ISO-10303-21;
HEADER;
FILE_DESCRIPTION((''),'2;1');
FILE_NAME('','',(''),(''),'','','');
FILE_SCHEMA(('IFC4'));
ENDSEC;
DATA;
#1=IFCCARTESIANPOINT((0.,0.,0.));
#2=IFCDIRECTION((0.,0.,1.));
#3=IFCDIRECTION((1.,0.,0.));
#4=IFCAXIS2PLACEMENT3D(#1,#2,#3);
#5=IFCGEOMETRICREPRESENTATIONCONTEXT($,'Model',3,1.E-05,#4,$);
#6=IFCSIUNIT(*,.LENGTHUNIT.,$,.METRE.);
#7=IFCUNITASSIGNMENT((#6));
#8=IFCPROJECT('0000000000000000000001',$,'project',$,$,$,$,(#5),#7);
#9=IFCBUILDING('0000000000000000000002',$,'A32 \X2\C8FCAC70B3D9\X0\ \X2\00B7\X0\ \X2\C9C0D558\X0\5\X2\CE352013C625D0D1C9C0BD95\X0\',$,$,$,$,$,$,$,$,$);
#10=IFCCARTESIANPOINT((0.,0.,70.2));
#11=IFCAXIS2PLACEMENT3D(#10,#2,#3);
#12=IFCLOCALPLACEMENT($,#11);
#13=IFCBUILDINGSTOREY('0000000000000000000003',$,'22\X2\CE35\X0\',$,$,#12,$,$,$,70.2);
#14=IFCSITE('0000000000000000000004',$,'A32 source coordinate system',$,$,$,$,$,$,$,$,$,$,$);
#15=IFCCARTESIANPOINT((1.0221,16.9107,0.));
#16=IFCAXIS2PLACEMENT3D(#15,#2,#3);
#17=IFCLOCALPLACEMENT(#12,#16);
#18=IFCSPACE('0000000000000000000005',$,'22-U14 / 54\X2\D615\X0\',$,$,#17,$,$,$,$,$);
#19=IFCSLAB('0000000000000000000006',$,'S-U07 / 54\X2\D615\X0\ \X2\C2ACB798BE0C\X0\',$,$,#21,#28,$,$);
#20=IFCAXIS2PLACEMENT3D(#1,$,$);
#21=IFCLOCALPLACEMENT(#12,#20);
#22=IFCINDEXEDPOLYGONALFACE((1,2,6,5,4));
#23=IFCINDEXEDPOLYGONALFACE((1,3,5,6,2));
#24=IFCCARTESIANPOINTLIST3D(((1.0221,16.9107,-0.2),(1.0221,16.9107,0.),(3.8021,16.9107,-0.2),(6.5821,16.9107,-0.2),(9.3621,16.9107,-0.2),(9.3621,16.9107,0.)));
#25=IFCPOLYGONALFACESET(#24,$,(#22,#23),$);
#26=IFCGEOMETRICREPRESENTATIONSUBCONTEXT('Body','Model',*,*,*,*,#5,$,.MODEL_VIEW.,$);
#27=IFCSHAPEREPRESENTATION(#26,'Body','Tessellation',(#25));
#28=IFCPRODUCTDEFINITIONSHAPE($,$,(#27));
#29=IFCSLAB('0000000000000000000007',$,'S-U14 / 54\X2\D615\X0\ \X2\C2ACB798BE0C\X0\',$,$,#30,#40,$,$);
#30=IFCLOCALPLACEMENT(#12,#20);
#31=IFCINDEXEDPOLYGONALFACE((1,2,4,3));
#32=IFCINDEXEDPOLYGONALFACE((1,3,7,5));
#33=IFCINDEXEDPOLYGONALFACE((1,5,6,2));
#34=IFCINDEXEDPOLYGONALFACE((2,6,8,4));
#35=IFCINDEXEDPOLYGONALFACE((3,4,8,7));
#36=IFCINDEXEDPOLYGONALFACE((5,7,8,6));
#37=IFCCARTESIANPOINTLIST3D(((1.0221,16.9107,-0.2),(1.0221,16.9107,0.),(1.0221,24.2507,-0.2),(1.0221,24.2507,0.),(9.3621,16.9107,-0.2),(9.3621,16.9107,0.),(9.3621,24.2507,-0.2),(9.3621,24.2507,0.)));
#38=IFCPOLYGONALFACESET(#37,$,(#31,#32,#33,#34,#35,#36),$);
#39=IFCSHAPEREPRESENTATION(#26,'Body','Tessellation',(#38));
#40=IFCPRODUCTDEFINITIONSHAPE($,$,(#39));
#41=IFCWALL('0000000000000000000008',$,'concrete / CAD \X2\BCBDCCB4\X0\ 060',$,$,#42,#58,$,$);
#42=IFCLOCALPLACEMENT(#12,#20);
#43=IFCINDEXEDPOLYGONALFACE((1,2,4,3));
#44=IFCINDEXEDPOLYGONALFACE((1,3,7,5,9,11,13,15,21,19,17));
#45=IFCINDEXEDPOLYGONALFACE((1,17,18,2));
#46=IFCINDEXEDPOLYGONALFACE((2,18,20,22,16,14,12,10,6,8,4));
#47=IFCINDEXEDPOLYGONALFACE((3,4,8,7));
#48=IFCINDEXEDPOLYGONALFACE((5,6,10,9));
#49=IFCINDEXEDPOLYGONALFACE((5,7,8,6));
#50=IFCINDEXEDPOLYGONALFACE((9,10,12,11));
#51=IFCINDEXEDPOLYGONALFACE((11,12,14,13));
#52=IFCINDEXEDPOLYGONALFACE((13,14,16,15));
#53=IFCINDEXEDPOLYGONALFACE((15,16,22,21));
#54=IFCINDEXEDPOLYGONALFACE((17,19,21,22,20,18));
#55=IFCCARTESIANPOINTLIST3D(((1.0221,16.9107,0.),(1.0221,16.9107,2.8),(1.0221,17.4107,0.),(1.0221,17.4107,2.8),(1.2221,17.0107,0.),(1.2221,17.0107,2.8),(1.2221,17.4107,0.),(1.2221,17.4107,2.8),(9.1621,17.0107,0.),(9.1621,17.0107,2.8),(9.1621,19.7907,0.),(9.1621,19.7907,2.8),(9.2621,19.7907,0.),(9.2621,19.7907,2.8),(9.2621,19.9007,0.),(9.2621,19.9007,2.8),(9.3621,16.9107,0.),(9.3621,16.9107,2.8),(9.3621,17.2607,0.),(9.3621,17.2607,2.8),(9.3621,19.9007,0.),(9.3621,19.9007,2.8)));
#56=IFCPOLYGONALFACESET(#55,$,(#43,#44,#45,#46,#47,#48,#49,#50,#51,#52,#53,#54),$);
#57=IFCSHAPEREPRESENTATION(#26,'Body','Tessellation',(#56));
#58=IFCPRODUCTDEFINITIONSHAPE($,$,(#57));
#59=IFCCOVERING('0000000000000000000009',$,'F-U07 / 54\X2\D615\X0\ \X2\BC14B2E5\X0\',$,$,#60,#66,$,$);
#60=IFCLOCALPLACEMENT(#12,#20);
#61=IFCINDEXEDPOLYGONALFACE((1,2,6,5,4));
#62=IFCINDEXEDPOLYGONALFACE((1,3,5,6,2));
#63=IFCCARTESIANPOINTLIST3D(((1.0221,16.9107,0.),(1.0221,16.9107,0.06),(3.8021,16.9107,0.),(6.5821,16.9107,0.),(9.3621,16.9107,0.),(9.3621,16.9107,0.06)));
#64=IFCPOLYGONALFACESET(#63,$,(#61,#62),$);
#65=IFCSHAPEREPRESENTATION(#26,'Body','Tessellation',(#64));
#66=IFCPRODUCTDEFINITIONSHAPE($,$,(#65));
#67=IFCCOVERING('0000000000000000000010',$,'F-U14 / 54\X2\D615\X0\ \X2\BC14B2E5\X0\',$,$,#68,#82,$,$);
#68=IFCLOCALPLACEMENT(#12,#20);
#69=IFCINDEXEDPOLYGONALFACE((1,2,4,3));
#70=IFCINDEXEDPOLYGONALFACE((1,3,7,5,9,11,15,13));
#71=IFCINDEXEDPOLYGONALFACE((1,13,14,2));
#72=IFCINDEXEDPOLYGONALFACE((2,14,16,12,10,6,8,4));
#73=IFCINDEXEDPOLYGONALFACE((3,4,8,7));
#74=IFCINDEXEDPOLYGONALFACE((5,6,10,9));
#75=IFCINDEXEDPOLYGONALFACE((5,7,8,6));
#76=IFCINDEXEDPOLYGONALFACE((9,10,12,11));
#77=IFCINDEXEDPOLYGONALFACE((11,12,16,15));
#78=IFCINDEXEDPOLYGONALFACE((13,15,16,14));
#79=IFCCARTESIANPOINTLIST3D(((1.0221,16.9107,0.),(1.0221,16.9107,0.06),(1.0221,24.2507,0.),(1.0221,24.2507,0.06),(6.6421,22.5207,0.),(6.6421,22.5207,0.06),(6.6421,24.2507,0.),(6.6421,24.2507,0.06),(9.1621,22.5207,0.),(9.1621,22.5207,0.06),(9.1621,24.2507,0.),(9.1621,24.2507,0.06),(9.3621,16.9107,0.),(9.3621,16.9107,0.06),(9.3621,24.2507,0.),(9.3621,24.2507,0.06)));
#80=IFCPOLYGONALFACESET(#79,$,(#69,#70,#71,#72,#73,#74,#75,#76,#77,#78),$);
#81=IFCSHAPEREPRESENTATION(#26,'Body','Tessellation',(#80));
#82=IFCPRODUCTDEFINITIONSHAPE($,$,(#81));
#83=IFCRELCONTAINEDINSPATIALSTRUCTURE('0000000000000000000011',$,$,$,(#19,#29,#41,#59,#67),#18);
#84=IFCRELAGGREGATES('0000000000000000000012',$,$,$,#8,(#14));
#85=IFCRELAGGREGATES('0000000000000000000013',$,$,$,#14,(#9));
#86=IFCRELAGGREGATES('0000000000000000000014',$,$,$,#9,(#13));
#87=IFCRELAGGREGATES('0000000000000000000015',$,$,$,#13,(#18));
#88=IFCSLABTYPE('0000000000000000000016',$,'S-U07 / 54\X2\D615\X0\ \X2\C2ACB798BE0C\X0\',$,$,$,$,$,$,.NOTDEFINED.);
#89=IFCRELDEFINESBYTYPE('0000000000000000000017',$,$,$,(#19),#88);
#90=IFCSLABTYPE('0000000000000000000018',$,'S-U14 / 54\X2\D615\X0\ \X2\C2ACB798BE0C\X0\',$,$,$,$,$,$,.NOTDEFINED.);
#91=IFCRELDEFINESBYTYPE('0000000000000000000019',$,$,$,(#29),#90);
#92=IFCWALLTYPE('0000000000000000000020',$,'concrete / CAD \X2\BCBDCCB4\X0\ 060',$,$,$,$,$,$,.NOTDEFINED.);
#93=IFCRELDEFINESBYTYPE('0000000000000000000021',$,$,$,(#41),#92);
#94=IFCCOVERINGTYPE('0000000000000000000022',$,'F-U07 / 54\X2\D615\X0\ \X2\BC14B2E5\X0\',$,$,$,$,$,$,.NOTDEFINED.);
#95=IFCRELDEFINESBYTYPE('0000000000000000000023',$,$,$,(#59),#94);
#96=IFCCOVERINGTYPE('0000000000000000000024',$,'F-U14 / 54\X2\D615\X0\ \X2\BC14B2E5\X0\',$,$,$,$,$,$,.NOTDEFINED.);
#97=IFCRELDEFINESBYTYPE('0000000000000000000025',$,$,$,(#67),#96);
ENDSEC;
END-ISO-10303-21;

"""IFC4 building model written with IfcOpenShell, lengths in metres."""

from ifc_helpers import new_model, si_unit, frame, origin, origin_with_axes, place, context, subcontext, project, spatial, polyline, outline, extrude, source, transform, mapped, type_object, type_shapes, element, save


model = new_model("IFC4")

# Units and contexts
model_context = context("Model", 3, precision=1e-05, world=origin_with_axes())
body_context = subcontext(model_context, "Body", "Model", "MODEL_VIEW")
ifc_project = project(units=[si_unit("LENGTHUNIT", "METRE")], contexts=[model_context])

# Site, building, storey, space
storey_placement = place(None, frame((0.0, 0.0, 70.2), z_axis=(0.0, 0.0, 1.0), x_axis=(1.0, 0.0, 0.0)))
space_1_placement = place(storey_placement, frame((1.0221, 16.9107, 0.0), z_axis=(0.0, 0.0, 1.0), x_axis=(1.0, 0.0, 0.0)))
site = spatial("IfcSite", under=ifc_project, Name="A32 source coordinate system")
building = spatial("IfcBuilding", under=site, Name="A32 주거동 · 지하5층–옥탑지붕")
storey = spatial("IfcBuildingStorey", under=building, at=storey_placement, Name="22층", Elevation=70.2)
space_1 = spatial("IfcSpace", under=storey, at=space_1_placement, Name="22-U14 / 54형")

# Slabs
slab_type_1 = type_object("IfcSlabType", Name="S-U07 / 54형 슬래브", PredefinedType="NOTDEFINED")
shared_shape_1 = source(origin(), body_context, "Body", "SweptSolid", [
    extrude(outline(polyline([(0.0, 0.0), (0.0, 0.0), (8.34, 0.0), (8.34, 0.0), (0.0, 0.0)])), frame((0.0, 0.0, -0.2)), (0.0, 0.0, 1.0), 0.2),
])
type_shapes(slab_type_1, [shared_shape_1])
slab_1_placement = place(space_1_placement, origin_with_axes())
element("IfcSlab", 1, at=slab_1_placement, inside=space_1, type_object=slab_type_1, Name="S-U07 / 54형 슬래브", context=body_context, shape_type="MappedRepresentation", body=[
    mapped(shared_shape_1, transform((0.0, 0.0, 0.0), scale=1.0)),
])
slab_type_2 = type_object("IfcSlabType", Name="S-U14 / 54형 슬래브", PredefinedType="NOTDEFINED")
shared_shape_2 = source(origin(), body_context, "Body", "SweptSolid", [
    extrude(outline(polyline([(0.0, 0.0), (0.0, 7.34), (8.34, 7.34), (8.34, 0.0), (0.0, 0.0)])), frame((0.0, 0.0, -0.2)), (0.0, 0.0, 1.0), 0.2),
])
type_shapes(slab_type_2, [shared_shape_2])
slab_2_placement = place(space_1_placement, origin_with_axes())
element("IfcSlab", 2, at=slab_2_placement, inside=space_1, type_object=slab_type_2, Name="S-U14 / 54형 슬래브", context=body_context, shape_type="MappedRepresentation", body=[
    mapped(shared_shape_2, transform((0.0, 0.0, 0.0), scale=1.0)),
])

# Wall
wall_type_1 = type_object("IfcWallType", Name="concrete / CAD 벽체 060", PredefinedType="NOTDEFINED")
shared_shape_3 = source(origin(), body_context, "Body", "SweptSolid", [
    extrude(outline(polyline([(0.2, 0.5), (0.2, 0.1), (8.14, 0.1), (8.14, 2.88), (8.24, 2.88), (8.24, 2.99), (8.34, 2.99), (8.34, 0.35), (8.34, 0.35), (8.34, 0.0), (0.0, 0.0), (0.0, 0.5), (0.2, 0.5)])), origin(), (0.0, 0.0, 1.0), 2.8),
])
type_shapes(wall_type_1, [shared_shape_3])
wall_1_placement = place(space_1_placement, origin_with_axes())
element("IfcWall", 3, at=wall_1_placement, inside=space_1, type_object=wall_type_1, Name="concrete / CAD 벽체 060", context=body_context, shape_type="MappedRepresentation", body=[
    mapped(shared_shape_3, transform((0.0, 0.0, 0.0), scale=1.0)),
])

# Coverings
covering_type_1 = type_object("IfcCoveringType", Name="F-U07 / 54형 바닥", PredefinedType="NOTDEFINED")
shared_shape_4 = source(origin(), body_context, "Body", "SweptSolid", [
    extrude(outline(polyline([(0.0, 0.0), (0.0, 0.0), (8.34, 0.0), (8.34, 0.0), (0.0, 0.0)])), origin(), (0.0, 0.0, 1.0), 0.06),
])
type_shapes(covering_type_1, [shared_shape_4])
covering_1_placement = place(space_1_placement, origin_with_axes())
element("IfcCovering", 4, at=covering_1_placement, inside=space_1, type_object=covering_type_1, Name="F-U07 / 54형 바닥", context=body_context, shape_type="MappedRepresentation", body=[
    mapped(shared_shape_4, transform((0.0, 0.0, 0.0), scale=1.0)),
])
covering_type_2 = type_object("IfcCoveringType", Name="F-U14 / 54형 바닥", PredefinedType="NOTDEFINED")
shared_shape_5 = source(origin(), body_context, "Body", "SweptSolid", [
    extrude(outline(polyline([(8.14, 7.34), (8.34, 7.34), (8.34, 0.0), (0.0, 0.0), (0.0, 7.34), (5.62, 7.34), (5.62, 5.61), (8.14, 5.61), (8.14, 7.34)])), origin(), (0.0, 0.0, 1.0), 0.06),
])
type_shapes(covering_type_2, [shared_shape_5])
covering_2_placement = place(space_1_placement, origin_with_axes())
element("IfcCovering", 5, at=covering_2_placement, inside=space_1, type_object=covering_type_2, Name="F-U14 / 54형 바닥", context=body_context, shape_type="MappedRepresentation", body=[
    mapped(shared_shape_5, transform((0.0, 0.0, 0.0), scale=1.0)),
])

save(model, "model.ifc")
